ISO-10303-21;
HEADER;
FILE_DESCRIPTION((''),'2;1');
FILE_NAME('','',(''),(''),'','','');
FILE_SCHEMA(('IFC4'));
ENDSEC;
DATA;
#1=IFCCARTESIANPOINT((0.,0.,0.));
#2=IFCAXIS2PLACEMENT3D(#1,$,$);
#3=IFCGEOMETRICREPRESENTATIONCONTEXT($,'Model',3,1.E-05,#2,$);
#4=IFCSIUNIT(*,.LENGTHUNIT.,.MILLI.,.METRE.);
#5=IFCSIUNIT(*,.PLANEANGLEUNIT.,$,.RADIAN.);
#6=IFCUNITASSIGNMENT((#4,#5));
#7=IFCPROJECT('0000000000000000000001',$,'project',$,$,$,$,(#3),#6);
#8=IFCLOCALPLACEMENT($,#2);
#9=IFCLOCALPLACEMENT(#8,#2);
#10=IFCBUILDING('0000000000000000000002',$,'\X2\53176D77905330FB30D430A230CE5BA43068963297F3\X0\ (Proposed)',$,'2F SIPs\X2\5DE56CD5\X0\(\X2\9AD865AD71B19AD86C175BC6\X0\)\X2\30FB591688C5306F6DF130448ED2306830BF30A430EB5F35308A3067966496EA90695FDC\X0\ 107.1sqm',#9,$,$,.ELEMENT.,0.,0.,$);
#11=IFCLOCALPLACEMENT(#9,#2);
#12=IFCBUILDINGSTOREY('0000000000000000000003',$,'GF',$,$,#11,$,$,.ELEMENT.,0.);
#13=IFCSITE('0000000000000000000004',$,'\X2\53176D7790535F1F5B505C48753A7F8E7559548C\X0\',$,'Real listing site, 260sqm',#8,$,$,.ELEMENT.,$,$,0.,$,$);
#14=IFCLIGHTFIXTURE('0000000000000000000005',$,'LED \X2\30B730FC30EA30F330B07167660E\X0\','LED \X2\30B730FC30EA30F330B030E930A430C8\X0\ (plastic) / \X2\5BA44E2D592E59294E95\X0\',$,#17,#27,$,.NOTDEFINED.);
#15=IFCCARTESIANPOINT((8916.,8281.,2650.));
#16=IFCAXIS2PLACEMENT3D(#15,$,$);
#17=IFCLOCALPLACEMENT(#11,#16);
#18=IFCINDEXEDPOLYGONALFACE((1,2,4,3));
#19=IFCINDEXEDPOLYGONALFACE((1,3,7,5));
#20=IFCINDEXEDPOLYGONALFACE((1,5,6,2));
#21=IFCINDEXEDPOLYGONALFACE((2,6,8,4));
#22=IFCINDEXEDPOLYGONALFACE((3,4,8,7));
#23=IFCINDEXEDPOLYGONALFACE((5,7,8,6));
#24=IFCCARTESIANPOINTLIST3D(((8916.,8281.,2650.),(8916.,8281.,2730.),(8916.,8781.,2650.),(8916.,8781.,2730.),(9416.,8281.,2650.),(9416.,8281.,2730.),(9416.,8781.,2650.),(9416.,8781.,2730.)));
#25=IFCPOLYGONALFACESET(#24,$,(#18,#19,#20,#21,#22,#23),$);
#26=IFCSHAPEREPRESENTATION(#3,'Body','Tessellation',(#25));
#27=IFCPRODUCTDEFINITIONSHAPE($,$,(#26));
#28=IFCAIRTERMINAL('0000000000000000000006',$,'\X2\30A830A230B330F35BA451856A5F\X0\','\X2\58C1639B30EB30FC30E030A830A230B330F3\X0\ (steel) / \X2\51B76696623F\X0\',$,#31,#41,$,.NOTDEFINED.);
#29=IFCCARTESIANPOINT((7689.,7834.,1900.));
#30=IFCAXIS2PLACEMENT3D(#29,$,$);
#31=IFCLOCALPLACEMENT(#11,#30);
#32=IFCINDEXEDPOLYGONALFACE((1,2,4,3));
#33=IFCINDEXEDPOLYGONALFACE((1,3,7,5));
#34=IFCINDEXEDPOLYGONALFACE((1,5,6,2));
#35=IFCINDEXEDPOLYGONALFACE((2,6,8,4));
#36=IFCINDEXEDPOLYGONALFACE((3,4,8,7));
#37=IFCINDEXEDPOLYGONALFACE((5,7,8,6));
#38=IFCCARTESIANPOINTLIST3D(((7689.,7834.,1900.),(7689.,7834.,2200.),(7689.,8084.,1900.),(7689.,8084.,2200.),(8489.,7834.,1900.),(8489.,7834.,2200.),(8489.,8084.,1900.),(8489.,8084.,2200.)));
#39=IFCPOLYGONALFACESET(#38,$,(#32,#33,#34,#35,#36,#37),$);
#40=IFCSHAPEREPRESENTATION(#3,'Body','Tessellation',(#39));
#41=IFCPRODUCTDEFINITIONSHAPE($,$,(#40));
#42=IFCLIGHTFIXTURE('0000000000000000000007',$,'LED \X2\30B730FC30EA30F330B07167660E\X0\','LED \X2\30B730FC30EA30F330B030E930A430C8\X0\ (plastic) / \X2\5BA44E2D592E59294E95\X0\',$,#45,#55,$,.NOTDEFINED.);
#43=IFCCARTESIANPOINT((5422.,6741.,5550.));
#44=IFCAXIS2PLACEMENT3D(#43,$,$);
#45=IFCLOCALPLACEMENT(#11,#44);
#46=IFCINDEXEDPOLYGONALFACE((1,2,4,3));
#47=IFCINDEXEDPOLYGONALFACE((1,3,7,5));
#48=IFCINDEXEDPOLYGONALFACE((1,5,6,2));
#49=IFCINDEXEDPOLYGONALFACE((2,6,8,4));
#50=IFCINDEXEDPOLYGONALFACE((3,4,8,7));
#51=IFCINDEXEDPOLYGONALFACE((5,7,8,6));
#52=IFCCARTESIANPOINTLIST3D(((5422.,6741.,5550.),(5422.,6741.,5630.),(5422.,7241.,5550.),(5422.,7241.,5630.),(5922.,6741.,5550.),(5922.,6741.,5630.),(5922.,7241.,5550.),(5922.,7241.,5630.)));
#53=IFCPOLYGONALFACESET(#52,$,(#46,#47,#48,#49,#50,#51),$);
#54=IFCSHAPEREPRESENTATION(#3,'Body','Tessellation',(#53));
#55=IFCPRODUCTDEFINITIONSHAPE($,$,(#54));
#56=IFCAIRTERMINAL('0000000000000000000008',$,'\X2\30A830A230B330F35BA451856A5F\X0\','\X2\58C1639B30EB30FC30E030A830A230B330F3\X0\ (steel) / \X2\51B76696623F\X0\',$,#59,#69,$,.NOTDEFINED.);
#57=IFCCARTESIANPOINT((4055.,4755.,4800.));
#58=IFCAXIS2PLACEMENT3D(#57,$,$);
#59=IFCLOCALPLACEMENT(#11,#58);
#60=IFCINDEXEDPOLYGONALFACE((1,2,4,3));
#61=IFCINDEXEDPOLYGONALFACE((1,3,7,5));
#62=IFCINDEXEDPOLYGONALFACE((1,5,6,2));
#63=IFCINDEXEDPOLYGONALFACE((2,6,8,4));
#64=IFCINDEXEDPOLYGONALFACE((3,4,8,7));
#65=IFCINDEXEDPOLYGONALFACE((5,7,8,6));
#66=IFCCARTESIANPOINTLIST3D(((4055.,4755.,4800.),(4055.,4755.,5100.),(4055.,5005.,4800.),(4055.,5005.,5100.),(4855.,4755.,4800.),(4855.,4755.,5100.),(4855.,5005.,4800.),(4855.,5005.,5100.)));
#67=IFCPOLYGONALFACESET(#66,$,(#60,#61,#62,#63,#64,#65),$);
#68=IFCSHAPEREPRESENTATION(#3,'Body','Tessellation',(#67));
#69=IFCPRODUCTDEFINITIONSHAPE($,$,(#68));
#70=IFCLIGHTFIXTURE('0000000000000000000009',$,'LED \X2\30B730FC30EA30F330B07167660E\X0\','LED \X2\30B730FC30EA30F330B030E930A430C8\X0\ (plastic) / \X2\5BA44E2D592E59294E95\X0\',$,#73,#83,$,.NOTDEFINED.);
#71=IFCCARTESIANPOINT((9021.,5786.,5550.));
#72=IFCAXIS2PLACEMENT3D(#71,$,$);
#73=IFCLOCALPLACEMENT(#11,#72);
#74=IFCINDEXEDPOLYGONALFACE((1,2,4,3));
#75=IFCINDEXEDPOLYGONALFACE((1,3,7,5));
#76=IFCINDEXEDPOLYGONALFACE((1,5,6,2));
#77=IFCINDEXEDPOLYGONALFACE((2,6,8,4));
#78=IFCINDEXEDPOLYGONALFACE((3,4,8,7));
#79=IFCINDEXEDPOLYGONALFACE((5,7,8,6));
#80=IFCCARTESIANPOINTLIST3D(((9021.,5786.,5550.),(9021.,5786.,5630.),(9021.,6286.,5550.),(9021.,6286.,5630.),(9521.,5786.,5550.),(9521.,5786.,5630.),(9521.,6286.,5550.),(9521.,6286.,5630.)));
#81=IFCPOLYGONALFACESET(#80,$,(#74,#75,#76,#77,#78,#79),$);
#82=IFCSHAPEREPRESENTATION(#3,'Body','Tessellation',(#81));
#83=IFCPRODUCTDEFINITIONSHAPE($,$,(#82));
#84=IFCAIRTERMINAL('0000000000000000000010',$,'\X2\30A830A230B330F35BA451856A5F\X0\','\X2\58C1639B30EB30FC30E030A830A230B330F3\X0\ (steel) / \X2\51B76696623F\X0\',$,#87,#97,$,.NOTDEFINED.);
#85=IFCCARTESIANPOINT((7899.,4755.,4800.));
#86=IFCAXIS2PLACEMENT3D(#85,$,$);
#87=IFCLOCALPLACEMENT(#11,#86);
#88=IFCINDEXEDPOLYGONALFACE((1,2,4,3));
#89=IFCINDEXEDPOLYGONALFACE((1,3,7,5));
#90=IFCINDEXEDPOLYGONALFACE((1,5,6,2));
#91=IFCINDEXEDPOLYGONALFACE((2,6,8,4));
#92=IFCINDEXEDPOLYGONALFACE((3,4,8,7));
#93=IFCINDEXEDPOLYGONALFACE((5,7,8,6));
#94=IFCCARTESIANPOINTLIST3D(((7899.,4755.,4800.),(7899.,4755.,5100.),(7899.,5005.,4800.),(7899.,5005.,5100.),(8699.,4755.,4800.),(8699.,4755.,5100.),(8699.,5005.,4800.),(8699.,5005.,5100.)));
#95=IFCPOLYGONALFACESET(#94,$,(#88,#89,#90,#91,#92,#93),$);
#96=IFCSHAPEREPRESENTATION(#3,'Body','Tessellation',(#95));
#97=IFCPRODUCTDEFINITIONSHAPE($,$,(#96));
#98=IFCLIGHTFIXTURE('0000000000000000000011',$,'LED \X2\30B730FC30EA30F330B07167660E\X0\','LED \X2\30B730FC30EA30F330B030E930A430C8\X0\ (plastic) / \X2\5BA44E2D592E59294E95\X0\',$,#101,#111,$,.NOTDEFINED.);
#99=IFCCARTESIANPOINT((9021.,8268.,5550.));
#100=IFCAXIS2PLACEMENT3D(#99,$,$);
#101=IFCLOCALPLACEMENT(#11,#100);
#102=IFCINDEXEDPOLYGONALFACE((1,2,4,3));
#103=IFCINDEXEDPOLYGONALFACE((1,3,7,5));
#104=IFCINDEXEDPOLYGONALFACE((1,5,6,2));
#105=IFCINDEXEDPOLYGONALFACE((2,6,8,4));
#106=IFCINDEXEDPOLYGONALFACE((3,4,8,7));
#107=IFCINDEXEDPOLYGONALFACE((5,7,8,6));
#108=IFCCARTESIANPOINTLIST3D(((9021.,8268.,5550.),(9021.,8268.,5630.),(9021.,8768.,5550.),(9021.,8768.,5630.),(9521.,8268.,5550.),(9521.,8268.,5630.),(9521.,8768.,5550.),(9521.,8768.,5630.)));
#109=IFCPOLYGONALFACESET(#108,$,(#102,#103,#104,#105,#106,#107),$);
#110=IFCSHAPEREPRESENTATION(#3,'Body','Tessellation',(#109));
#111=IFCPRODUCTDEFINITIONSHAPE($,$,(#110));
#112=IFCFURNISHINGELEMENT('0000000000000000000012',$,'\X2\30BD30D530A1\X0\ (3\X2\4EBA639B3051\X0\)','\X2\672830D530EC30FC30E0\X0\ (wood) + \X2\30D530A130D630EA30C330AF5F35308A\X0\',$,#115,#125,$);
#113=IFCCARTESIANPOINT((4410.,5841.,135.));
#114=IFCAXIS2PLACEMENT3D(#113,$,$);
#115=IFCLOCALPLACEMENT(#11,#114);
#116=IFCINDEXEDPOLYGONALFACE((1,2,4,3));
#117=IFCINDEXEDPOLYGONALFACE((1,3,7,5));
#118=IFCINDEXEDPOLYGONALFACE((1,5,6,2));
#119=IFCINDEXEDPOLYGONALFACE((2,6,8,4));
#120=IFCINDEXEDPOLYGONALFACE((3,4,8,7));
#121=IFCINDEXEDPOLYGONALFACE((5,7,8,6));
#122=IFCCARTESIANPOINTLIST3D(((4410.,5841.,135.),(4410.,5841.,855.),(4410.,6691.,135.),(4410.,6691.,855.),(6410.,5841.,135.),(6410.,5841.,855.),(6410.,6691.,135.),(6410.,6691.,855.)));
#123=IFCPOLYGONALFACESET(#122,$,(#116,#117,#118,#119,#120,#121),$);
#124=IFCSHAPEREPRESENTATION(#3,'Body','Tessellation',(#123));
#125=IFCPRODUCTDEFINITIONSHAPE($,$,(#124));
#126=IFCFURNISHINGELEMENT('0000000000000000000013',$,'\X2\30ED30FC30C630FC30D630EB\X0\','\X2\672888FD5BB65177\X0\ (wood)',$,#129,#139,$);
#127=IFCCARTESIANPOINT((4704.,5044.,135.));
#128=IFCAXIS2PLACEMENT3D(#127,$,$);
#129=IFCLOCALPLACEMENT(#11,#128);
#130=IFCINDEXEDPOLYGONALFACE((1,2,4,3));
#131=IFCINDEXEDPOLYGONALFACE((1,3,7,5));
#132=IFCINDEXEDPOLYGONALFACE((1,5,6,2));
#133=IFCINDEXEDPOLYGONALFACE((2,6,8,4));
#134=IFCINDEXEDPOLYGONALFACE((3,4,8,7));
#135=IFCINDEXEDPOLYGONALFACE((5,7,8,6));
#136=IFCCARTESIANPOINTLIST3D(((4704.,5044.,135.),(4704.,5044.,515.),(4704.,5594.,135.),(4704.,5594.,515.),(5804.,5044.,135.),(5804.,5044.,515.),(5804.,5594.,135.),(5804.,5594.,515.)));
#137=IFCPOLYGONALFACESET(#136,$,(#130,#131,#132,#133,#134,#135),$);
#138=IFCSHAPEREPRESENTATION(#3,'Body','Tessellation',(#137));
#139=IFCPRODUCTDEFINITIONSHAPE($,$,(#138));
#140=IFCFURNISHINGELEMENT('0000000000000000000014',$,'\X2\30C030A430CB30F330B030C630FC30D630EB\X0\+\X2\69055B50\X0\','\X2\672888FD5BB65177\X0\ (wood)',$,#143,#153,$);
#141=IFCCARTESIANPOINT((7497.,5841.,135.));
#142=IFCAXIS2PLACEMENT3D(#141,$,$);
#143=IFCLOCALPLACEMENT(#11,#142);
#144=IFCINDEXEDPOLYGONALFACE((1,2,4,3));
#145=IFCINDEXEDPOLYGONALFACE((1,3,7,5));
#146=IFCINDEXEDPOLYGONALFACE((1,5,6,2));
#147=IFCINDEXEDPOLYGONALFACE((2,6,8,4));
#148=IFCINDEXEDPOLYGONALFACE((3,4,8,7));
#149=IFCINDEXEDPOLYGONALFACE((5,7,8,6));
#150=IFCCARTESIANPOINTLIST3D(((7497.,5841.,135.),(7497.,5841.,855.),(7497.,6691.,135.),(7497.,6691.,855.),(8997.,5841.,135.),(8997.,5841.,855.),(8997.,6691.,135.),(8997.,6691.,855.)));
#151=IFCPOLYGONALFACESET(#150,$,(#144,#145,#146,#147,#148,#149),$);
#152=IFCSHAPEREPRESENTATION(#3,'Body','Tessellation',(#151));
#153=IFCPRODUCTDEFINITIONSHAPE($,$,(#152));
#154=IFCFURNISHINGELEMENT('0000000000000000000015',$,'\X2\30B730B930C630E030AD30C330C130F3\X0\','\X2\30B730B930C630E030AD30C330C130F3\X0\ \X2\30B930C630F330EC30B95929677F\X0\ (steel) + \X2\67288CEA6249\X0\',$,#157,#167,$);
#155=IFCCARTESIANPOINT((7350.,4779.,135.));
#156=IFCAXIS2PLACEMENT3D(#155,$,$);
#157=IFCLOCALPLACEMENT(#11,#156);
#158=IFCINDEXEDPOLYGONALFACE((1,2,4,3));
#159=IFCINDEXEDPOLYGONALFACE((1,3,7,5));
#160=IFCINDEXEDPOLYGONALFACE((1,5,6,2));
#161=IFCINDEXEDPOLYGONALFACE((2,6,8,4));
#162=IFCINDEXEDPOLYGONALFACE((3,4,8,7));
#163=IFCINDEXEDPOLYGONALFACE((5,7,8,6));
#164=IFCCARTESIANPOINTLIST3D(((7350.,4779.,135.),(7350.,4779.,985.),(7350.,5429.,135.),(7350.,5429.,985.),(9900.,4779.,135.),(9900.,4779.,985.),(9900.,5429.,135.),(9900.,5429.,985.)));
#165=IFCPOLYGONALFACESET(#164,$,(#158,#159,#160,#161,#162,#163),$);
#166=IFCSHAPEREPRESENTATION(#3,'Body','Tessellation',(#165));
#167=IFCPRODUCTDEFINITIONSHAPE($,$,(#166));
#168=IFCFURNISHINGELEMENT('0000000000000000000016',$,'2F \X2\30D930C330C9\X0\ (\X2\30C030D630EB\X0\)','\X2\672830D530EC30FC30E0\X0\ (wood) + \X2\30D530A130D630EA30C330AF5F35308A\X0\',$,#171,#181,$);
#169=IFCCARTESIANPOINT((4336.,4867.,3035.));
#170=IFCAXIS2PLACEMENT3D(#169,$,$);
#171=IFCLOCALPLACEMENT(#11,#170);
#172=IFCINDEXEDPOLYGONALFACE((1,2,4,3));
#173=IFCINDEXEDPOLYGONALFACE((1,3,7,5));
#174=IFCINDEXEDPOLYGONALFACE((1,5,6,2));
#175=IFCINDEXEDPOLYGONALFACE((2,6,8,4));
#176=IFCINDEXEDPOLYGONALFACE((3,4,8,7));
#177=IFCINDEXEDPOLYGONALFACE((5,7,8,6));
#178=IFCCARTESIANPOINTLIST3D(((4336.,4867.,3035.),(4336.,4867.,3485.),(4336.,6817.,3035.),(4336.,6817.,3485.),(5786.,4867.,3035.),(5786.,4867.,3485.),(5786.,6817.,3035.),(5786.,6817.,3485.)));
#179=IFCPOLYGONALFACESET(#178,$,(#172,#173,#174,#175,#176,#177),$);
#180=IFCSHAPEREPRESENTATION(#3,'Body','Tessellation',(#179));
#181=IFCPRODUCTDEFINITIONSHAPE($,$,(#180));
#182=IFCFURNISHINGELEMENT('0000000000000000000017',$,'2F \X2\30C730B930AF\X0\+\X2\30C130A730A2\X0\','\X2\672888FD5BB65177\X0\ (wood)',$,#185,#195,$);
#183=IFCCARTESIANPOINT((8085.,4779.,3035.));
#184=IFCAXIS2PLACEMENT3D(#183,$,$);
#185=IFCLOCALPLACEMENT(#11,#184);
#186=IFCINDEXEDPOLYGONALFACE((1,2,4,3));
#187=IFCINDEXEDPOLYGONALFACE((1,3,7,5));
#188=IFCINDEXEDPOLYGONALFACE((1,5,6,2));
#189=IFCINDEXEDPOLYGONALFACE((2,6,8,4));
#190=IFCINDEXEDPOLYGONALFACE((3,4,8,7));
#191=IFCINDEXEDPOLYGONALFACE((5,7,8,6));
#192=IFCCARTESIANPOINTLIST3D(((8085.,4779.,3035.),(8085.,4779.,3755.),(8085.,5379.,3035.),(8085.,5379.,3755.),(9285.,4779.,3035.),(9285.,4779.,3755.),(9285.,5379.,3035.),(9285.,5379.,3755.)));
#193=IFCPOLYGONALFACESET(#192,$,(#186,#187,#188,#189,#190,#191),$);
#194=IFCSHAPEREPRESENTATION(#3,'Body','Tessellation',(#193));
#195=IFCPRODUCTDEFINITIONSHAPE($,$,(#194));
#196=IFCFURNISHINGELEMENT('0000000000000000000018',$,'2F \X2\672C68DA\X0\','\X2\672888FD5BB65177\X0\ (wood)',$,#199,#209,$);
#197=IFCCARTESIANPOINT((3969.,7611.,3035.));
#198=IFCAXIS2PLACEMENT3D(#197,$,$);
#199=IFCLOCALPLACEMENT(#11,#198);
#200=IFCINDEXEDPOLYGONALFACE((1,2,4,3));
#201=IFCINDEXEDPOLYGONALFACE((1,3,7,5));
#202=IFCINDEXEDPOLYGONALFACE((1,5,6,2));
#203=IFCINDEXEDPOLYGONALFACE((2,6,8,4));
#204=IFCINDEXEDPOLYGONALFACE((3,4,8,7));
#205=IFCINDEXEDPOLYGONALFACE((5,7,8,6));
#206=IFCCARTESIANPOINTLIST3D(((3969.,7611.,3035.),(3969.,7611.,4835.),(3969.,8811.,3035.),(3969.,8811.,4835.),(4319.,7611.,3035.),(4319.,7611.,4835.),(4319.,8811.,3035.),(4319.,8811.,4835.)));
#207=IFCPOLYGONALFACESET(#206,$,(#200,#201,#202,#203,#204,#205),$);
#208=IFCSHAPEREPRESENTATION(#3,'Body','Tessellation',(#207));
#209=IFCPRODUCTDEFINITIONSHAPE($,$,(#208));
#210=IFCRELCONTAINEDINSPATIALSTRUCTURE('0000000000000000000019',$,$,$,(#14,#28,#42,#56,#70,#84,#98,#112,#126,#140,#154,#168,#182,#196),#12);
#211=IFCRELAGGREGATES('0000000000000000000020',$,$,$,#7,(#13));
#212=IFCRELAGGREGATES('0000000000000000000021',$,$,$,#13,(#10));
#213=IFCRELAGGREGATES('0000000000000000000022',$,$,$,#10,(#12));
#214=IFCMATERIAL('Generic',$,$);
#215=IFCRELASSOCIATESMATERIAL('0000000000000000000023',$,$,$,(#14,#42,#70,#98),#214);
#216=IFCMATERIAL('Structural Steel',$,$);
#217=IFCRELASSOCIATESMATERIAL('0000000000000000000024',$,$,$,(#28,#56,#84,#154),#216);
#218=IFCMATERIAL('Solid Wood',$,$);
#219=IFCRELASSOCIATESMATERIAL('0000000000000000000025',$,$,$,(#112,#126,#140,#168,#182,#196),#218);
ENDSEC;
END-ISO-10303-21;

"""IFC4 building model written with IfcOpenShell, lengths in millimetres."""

from ifc_helpers import new_model, si_unit, frame, frame_2d, origin, place, context, project, spatial, rectangle, extrude, material, element, save


model = new_model("IFC4")

# Units and contexts
model_context = context("Model", 3, precision=1e-05, world=origin())
ifc_project = project(units=[si_unit("LENGTHUNIT", "METRE", prefix="MILLI"), si_unit("PLANEANGLEUNIT", "RADIAN")], contexts=[model_context])

# Site, building, storey
site_placement = place(None, origin())
site = spatial("IfcSite", under=ifc_project, at=site_placement, Name="北海道弟子屈町美留和", ObjectType="Real listing site, 260sqm", CompositionType="ELEMENT", RefElevation=0.0)
building_placement = place(site_placement, origin())
building = spatial("IfcBuilding", under=site, at=building_placement, Name="北海道・ピアノ室と防音 (Proposed)", ObjectType="2F SIPs工法(高断熱高気密)・外装は深い軒とタイル張りで除雪適応 107.1sqm", CompositionType="ELEMENT", ElevationOfRefHeight=0.0, ElevationOfTerrain=0.0)
storey_placement = place(building_placement, origin())
storey = spatial("IfcBuildingStorey", under=building, at=storey_placement, Name="GF", CompositionType="ELEMENT", Elevation=0.0)

# Shared definitions
ifc_material_1 = material(Name="Solid Wood")

# Shared definitions
ifc_material_2 = material(Name="Structural Steel")

# Shared definitions
ifc_material_3 = material(Name="Generic")

# Light fixture
light_fixture_1_placement = place(storey_placement, frame((8916.0, 8281.0, 2650.0)))
element("IfcLightFixture", 1, at=light_fixture_1_placement, inside=storey, material=ifc_material_3, Name="LED シーリング照明", Description="LED シーリングライト (plastic) / 室中央天井", PredefinedType="NOTDEFINED", context=model_context, shape_type="SweptSolid", body=[
    extrude(rectangle(XDim=500.0, YDim=500.0, at=frame_2d((250.0, 250.0))), frame((8916.0, 8281.0, 2650.0)), (0.0, 0.0, 1.0), 80.0),
])

# Air terminal
air_terminal_1_placement = place(storey_placement, frame((7689.0, 7834.0, 1900.0)))
element("IfcAirTerminal", 2, at=air_terminal_1_placement, inside=storey, material=ifc_material_2, Name="エアコン室内機", Description="壁掛ルームエアコン (steel) / 冷暖房", PredefinedType="NOTDEFINED", context=model_context, shape_type="SweptSolid", body=[
    extrude(rectangle(XDim=800.0, YDim=250.0, at=frame_2d((400.0, 125.0))), frame((7689.0, 7834.0, 1900.0)), (0.0, 0.0, 1.0), 300.0),
])

# Light fixture
light_fixture_2_placement = place(storey_placement, frame((5422.0, 6741.0, 5550.0)))
element("IfcLightFixture", 3, at=light_fixture_2_placement, inside=storey, material=ifc_material_3, Name="LED シーリング照明", Description="LED シーリングライト (plastic) / 室中央天井", PredefinedType="NOTDEFINED", context=model_context, shape_type="SweptSolid", body=[
    extrude(rectangle(XDim=500.0, YDim=500.0, at=frame_2d((250.0, 250.0))), frame((5422.0, 6741.0, 5550.0)), (0.0, 0.0, 1.0), 80.0),
])

# Air terminal
air_terminal_2_placement = place(storey_placement, frame((4055.0, 4755.0, 4800.0)))
element("IfcAirTerminal", 4, at=air_terminal_2_placement, inside=storey, material=ifc_material_2, Name="エアコン室内機", Description="壁掛ルームエアコン (steel) / 冷暖房", PredefinedType="NOTDEFINED", context=model_context, shape_type="SweptSolid", body=[
    extrude(rectangle(XDim=800.0, YDim=250.0, at=frame_2d((400.0, 125.0))), frame((4055.0, 4755.0, 4800.0)), (0.0, 0.0, 1.0), 300.0),
])

# Light fixture
light_fixture_3_placement = place(storey_placement, frame((9021.0, 5786.0, 5550.0)))
element("IfcLightFixture", 5, at=light_fixture_3_placement, inside=storey, material=ifc_material_3, Name="LED シーリング照明", Description="LED シーリングライト (plastic) / 室中央天井", PredefinedType="NOTDEFINED", context=model_context, shape_type="SweptSolid", body=[
    extrude(rectangle(XDim=500.0, YDim=500.0, at=frame_2d((250.0, 250.0))), frame((9021.0, 5786.0, 5550.0)), (0.0, 0.0, 1.0), 80.0),
])

# Air terminal
air_terminal_3_placement = place(storey_placement, frame((7899.0, 4755.0, 4800.0)))
element("IfcAirTerminal", 6, at=air_terminal_3_placement, inside=storey, material=ifc_material_2, Name="エアコン室内機", Description="壁掛ルームエアコン (steel) / 冷暖房", PredefinedType="NOTDEFINED", context=model_context, shape_type="SweptSolid", body=[
    extrude(rectangle(XDim=800.0, YDim=250.0, at=frame_2d((400.0, 125.0))), frame((7899.0, 4755.0, 4800.0)), (0.0, 0.0, 1.0), 300.0),
])

# Light fixture
light_fixture_4_placement = place(storey_placement, frame((9021.0, 8268.0, 5550.0)))
element("IfcLightFixture", 7, at=light_fixture_4_placement, inside=storey, material=ifc_material_3, Name="LED シーリング照明", Description="LED シーリングライト (plastic) / 室中央天井", PredefinedType="NOTDEFINED", context=model_context, shape_type="SweptSolid", body=[
    extrude(rectangle(XDim=500.0, YDim=500.0, at=frame_2d((250.0, 250.0))), frame((9021.0, 8268.0, 5550.0)), (0.0, 0.0, 1.0), 80.0),
])

# Furnishing elements
furnishing_1_placement = place(storey_placement, frame((4410.0, 5841.0, 135.0)))
element("IfcFurnishingElement", 8, at=furnishing_1_placement, inside=storey, material=ifc_material_1, Name="ソファ (3人掛け)", Description="木フレーム (wood) + ファブリック張り", context=model_context, shape_type="SweptSolid", body=[
    extrude(rectangle(XDim=2000.0, YDim=850.0, at=frame_2d((1000.0, 425.0))), frame((4410.0, 5841.0, 135.0)), (0.0, 0.0, 1.0), 720.0),
])
furnishing_2_placement = place(storey_placement, frame((4704.0, 5044.0, 135.0)))
element("IfcFurnishingElement", 9, at=furnishing_2_placement, inside=storey, material=ifc_material_1, Name="ローテーブル", Description="木製家具 (wood)", context=model_context, shape_type="SweptSolid", body=[
    extrude(rectangle(XDim=1100.0, YDim=550.0, at=frame_2d((550.0, 275.0))), frame((4704.0, 5044.0, 135.0)), (0.0, 0.0, 1.0), 380.0),
])
furnishing_3_placement = place(storey_placement, frame((7497.0, 5841.0, 135.0)))
element("IfcFurnishingElement", 10, at=furnishing_3_placement, inside=storey, material=ifc_material_1, Name="ダイニングテーブル+椅子", Description="木製家具 (wood)", context=model_context, shape_type="SweptSolid", body=[
    extrude(rectangle(XDim=1500.0, YDim=850.0, at=frame_2d((750.0, 425.0))), frame((7497.0, 5841.0, 135.0)), (0.0, 0.0, 1.0), 720.0),
])
furnishing_4_placement = place(storey_placement, frame((7350.0, 4779.0, 135.0)))
element("IfcFurnishingElement", 11, at=furnishing_4_placement, inside=storey, material=ifc_material_2, Name="システムキッチン", Description="システムキッチン ステンレス天板 (steel) + 木質扉", context=model_context, shape_type="SweptSolid", body=[
    extrude(rectangle(XDim=2550.0, YDim=650.0, at=frame_2d((1275.0, 325.0))), frame((7350.0, 4779.0, 135.0)), (0.0, 0.0, 1.0), 850.0),
])
furnishing_5_placement = place(storey_placement, frame((4336.0, 4867.0, 3035.0)))
element("IfcFurnishingElement", 12, at=furnishing_5_placement, inside=storey, material=ifc_material_1, Name="2F ベッド (ダブル)", Description="木フレーム (wood) + ファブリック張り", context=model_context, shape_type="SweptSolid", body=[
    extrude(rectangle(XDim=1450.0, YDim=1950.0, at=frame_2d((725.0, 975.0))), frame((4336.0, 4867.0, 3035.0)), (0.0, 0.0, 1.0), 450.0),
])
furnishing_6_placement = place(storey_placement, frame((8085.0, 4779.0, 3035.0)))
element("IfcFurnishingElement", 13, at=furnishing_6_placement, inside=storey, material=ifc_material_1, Name="2F デスク+チェア", Description="木製家具 (wood)", context=model_context, shape_type="SweptSolid", body=[
    extrude(rectangle(XDim=1200.0, YDim=600.0, at=frame_2d((600.0, 300.0))), frame((8085.0, 4779.0, 3035.0)), (0.0, 0.0, 1.0), 720.0),
])
furnishing_7_placement = place(storey_placement, frame((3969.0, 7611.0, 3035.0)))
element("IfcFurnishingElement", 14, at=furnishing_7_placement, inside=storey, material=ifc_material_1, Name="2F 本棚", Description="木製家具 (wood)", context=model_context, shape_type="SweptSolid", body=[
    extrude(rectangle(XDim=350.0, YDim=1200.0, at=frame_2d((175.0, 600.0))), frame((3969.0, 7611.0, 3035.0)), (0.0, 0.0, 1.0), 1800.0),
])

save(model, "model.ifc")
